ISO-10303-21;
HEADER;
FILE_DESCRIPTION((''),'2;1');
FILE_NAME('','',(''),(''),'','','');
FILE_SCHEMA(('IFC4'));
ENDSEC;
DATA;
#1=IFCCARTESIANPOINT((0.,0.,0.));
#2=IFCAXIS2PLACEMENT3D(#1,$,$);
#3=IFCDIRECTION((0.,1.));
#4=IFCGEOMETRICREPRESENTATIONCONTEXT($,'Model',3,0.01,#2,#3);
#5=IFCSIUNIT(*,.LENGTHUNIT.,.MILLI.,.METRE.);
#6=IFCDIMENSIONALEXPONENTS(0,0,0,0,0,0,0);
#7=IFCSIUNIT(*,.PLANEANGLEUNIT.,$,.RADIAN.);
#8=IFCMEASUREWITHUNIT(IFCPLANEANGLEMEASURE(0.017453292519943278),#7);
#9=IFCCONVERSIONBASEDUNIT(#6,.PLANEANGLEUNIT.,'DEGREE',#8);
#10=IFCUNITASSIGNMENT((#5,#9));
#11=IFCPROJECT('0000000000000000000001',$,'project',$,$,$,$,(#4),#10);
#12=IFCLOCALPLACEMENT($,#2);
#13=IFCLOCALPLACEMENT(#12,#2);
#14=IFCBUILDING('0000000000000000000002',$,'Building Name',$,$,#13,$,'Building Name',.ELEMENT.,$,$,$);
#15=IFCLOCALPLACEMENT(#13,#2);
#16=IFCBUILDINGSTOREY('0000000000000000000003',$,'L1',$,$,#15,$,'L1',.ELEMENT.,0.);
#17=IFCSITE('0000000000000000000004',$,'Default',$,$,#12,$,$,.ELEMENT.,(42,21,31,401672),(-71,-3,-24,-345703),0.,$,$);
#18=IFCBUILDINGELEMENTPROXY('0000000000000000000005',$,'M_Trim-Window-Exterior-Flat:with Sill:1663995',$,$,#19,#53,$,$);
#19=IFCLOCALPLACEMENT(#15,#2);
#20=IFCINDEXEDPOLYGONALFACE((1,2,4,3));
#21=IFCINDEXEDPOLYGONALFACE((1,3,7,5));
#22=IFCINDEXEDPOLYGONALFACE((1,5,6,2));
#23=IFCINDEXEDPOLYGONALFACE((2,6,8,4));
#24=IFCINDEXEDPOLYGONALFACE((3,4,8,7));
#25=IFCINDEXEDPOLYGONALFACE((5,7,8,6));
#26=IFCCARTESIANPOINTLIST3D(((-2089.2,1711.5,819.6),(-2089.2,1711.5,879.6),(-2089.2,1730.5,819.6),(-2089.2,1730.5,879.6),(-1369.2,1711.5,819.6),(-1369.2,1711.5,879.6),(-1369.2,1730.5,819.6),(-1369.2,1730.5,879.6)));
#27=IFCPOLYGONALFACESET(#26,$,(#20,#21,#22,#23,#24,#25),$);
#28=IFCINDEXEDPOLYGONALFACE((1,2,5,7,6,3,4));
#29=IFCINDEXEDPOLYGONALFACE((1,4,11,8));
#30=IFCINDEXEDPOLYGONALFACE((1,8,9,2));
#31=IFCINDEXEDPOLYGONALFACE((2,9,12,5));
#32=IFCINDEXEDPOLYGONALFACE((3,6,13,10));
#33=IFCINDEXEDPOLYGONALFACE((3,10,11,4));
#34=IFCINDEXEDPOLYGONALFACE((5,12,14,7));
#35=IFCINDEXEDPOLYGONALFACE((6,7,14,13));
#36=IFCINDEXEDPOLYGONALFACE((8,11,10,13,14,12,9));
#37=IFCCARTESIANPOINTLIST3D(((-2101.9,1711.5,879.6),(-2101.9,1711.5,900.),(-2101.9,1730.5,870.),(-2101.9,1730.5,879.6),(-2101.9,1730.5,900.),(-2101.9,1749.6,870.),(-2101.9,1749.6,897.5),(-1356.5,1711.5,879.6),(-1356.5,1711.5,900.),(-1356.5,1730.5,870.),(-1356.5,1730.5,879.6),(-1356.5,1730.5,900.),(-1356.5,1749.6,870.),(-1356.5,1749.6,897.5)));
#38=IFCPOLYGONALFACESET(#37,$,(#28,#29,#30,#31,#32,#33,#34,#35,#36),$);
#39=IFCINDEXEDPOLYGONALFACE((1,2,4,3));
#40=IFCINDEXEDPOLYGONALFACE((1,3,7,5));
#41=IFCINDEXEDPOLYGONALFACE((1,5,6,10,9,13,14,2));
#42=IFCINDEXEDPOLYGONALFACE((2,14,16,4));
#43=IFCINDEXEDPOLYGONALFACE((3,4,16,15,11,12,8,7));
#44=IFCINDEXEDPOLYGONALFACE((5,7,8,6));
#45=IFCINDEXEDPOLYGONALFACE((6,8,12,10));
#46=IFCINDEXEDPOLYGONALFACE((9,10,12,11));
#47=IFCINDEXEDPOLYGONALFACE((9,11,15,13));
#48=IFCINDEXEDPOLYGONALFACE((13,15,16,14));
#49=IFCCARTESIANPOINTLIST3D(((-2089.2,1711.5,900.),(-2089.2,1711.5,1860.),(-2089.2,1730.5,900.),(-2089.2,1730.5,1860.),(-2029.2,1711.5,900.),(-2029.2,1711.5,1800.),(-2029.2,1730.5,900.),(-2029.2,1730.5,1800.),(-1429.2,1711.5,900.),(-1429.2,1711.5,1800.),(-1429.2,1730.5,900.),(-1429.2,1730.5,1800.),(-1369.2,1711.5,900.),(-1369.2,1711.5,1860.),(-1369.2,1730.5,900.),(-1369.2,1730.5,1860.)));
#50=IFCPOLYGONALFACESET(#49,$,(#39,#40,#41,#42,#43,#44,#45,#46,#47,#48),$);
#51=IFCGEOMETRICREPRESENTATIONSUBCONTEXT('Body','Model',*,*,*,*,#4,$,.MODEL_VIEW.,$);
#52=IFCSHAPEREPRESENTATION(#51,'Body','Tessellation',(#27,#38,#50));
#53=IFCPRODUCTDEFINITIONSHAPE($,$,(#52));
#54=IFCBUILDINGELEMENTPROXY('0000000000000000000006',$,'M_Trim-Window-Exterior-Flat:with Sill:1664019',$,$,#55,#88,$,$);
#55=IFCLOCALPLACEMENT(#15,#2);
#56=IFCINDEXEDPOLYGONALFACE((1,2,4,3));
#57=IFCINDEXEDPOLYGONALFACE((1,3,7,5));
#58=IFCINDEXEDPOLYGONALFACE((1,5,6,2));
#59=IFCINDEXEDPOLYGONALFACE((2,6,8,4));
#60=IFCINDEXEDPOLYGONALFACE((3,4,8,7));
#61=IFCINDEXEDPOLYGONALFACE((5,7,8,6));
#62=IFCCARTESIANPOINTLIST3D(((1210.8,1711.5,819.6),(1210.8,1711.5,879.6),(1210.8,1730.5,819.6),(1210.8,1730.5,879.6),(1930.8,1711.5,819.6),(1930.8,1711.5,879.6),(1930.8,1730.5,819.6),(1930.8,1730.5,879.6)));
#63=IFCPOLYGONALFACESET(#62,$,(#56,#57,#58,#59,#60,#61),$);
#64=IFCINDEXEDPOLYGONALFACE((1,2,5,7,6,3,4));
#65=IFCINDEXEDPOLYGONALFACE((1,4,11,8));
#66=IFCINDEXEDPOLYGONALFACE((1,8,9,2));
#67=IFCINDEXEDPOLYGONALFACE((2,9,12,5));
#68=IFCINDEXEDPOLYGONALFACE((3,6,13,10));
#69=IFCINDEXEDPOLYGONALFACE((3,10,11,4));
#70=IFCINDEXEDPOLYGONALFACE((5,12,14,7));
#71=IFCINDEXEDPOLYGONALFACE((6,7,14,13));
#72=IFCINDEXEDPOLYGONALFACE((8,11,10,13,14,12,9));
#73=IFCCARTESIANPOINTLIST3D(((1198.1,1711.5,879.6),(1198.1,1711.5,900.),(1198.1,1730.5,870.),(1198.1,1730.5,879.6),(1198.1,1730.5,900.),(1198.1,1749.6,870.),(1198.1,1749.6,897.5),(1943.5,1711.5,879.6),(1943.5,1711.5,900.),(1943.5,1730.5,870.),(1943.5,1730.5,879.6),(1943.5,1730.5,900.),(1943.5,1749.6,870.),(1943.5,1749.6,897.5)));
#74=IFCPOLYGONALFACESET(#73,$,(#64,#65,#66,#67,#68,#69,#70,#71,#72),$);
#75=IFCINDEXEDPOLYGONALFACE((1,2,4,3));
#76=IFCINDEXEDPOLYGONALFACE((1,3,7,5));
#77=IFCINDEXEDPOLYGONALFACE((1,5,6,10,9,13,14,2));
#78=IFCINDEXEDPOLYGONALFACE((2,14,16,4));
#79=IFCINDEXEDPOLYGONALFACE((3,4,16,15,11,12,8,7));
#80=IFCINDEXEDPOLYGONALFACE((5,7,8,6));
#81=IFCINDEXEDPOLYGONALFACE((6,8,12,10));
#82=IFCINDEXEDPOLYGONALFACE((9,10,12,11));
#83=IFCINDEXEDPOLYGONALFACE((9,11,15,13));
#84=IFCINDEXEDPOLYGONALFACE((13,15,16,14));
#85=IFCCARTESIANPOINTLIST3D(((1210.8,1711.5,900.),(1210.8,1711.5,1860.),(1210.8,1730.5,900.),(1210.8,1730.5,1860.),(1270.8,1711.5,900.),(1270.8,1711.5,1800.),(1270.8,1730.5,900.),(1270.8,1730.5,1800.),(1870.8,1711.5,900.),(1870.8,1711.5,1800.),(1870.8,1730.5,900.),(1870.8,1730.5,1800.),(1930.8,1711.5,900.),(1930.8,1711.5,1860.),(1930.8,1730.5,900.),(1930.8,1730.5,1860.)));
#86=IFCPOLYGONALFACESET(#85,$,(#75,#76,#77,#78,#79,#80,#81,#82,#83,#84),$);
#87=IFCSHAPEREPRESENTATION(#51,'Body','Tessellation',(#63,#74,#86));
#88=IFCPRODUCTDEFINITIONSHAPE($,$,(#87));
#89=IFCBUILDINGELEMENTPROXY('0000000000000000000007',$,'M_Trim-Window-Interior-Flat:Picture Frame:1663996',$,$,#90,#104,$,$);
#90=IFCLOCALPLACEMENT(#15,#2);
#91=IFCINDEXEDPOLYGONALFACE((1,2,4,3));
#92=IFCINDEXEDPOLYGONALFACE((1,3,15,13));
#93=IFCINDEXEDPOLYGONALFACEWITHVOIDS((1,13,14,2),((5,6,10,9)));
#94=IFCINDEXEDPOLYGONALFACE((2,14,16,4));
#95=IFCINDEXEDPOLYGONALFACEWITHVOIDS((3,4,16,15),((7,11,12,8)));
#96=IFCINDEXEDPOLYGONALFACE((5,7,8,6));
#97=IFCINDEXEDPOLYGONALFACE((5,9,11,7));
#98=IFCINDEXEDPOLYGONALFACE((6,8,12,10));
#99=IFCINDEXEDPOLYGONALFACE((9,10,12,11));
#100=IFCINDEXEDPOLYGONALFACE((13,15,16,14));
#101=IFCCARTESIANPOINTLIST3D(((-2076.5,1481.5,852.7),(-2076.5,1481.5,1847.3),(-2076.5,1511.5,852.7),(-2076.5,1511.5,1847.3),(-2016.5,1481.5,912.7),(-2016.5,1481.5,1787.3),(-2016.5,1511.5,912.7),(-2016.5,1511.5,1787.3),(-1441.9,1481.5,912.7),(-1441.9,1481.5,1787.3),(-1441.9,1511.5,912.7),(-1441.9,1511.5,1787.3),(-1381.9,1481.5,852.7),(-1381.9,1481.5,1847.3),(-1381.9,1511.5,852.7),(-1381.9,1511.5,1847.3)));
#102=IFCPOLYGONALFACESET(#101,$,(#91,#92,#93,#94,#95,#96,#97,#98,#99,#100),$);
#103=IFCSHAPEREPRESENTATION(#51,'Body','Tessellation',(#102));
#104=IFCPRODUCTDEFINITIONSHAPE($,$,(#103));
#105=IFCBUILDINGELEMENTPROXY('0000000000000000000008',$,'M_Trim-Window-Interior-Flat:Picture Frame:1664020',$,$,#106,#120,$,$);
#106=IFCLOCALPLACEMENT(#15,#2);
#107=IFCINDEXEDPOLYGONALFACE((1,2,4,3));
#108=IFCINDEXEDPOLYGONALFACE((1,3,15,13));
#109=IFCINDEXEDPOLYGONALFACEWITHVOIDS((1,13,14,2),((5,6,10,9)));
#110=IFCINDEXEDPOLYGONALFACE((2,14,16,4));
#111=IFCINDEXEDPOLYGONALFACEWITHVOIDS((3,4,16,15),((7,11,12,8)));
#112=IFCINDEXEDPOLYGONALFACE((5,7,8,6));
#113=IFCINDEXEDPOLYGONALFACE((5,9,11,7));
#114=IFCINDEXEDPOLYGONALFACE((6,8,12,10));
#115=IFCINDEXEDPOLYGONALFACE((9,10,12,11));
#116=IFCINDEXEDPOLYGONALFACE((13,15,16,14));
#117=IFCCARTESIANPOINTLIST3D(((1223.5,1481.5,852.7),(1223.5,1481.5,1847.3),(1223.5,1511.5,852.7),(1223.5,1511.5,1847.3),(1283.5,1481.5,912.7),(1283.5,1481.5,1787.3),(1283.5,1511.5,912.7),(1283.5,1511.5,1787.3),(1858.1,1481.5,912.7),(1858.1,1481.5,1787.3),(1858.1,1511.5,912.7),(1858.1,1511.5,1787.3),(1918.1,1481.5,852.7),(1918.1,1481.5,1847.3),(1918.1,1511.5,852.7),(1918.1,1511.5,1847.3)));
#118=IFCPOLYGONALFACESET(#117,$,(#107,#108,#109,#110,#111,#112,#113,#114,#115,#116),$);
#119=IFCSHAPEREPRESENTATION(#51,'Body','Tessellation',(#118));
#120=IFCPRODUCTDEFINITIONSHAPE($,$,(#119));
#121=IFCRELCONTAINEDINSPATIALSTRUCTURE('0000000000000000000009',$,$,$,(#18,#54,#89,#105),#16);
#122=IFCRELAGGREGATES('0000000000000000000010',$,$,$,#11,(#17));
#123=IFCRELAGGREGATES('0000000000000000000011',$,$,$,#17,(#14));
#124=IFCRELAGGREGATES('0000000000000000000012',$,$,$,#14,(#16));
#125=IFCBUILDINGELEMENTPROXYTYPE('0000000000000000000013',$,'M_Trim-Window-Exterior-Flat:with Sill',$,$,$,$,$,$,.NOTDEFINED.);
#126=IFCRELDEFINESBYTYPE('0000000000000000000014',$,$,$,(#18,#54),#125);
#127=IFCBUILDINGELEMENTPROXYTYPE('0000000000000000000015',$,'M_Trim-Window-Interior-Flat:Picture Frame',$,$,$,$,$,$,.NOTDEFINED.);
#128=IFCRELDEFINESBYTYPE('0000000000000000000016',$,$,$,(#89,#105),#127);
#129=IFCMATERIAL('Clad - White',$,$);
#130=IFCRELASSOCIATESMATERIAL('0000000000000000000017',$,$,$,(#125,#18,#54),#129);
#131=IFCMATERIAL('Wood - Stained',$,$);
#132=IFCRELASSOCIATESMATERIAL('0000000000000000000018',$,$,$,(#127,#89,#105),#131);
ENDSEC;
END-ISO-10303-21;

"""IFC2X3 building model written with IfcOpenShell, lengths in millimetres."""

from ifc_helpers import new_model, entity, si_unit, converted_unit, direction, frame, frame_2d, origin, place, context, subcontext, project, spatial, polyline, rectangle, outline, extrude, source, transform, mapped, material, type_object, type_shapes, element, save


model = new_model("IFC2X3")

# Units and contexts
model_context = context("Model", 3, precision=0.01, world=origin(), true_north=direction((0.0, 1.0)))
body_context = subcontext(model_context, "Body", "Model", "MODEL_VIEW")
ifc_project = project(units=[si_unit("LENGTHUNIT", "METRE", prefix="MILLI"), converted_unit("PLANEANGLEUNIT", "DEGREE", entity("IfcPlaneAngleMeasure", 0.017453292519943278), si_unit("PLANEANGLEUNIT", "RADIAN"), dimensions=[0, 0, 0, 0, 0, 0, 0])], contexts=[model_context])

# Site, building, storey
site_placement = place(None, origin())
site = spatial("IfcSite", under=ifc_project, at=site_placement, Name="Default", CompositionType="ELEMENT", RefLatitude=(42, 21, 31, 401672), RefLongitude=(-71, -3, -24, -345703), RefElevation=0.0)
building_placement = place(site_placement, origin())
building = spatial("IfcBuilding", under=site, at=building_placement, Name="Building Name", LongName="Building Name", CompositionType="ELEMENT")
storey_placement = place(building_placement, origin())
storey = spatial("IfcBuildingStorey", under=building, at=storey_placement, Name="L1", LongName="L1", CompositionType="ELEMENT", Elevation=0.0)

# Building element proxies
ifc_material_1 = material(Name="Clad - White")
ifc_material_2 = material(Name="Wood - Stained")
building_element_proxy_type_1 = type_object("IfcBuildingElementProxyType", Name="M_Trim-Window-Exterior-Flat:with Sill", PredefinedType="NOTDEFINED", material=ifc_material_1)
shared_shape_1 = source(origin(), body_context, "Body", "SweptSolid", [
    extrude(rectangle(XDim=720.0, YDim=60.0, at=frame_2d((0.0, 0.0), x_axis=(1.0, 0.0))), frame((0.0, -950.4, 0.0), z_axis=(0.0, 0.0, 1.0), x_axis=(-1.0, 0.0, 0.0)), (0.0, 0.0, 1.0), 19.0),
    extrude(outline(polyline([(-19.0, -15.2), (0.0, -15.2), (0.0, -5.7), (19.0, -5.7), (19.0, 14.8), (0.0, 14.8), (-19.0, 12.3), (-19.0, -15.2)])), frame((-372.7, -914.8, 19.0), z_axis=(1.0, 0.0, 0.0), x_axis=(0.0, 0.0, -1.0)), (0.0, 0.0, 1.0), 745.4),
    extrude(outline(polyline([(-495.0, -360.0), (465.0, -360.0), (465.0, -300.0), (-435.0, -300.0), (-435.0, 300.0), (465.0, 300.0), (465.0, 360.0), (-495.0, 360.0), (-495.0, -360.0)])), frame((0.0, -435.0, 0.0), z_axis=(0.0, 0.0, 1.0), x_axis=(0.0, -1.0, 0.0)), (0.0, 0.0, 1.0), 19.0),
])
type_shapes(building_element_proxy_type_1, [shared_shape_1])
for number, where, z_axis, x_axis, name in (
    (1, (-1729.2, 1711.5, 1800.0), (0.0, 1.0, 0.0), (-1.0, 0.0, 0.0), "M_Trim-Window-Exterior-Flat:with Sill:1663995"),
    (2, (1570.8, 1711.5, 1800.0), (0.0, 1.0, 0.0), (-1.0, 0.0, 0.0), "M_Trim-Window-Exterior-Flat:with Sill:1664019"),
):
    element("IfcBuildingElementProxy", number, at=place(storey_placement, frame(where, z_axis=z_axis, x_axis=x_axis)), inside=storey, type_object=building_element_proxy_type_1, material=ifc_material_1, Name=name, context=body_context, shape_type="MappedRepresentation", body=[
        mapped(shared_shape_1, transform((0.0, 0.0, 0.0), scale=1.0)),
    ])
building_element_proxy_type_2 = type_object("IfcBuildingElementProxyType", Name="M_Trim-Window-Interior-Flat:Picture Frame", PredefinedType="NOTDEFINED", material=ifc_material_2)
shared_shape_2 = source(origin(), body_context, "Body", "SweptSolid", [
    extrude(outline(polyline([(-347.3, -497.3), (347.3, -497.3), (347.3, 497.3), (-347.3, 497.3), (-347.3, -497.3)]), holes=[polyline([(-287.3, -437.3), (-287.3, 437.3), (287.3, 437.3), (287.3, -437.3), (-287.3, -437.3)])]), frame((0.0, -450.0, 0.0), z_axis=(0.0, 0.0, 1.0), x_axis=(-1.0, 0.0, 0.0)), (0.0, 0.0, 1.0), 30.0),
])
type_shapes(building_element_proxy_type_2, [shared_shape_2])
for number, where, z_axis, x_axis, name in (
    (3, (-1729.2, 1511.5, 1800.0), (0.0, -1.0, 0.0), (1.0, 0.0, 0.0), "M_Trim-Window-Interior-Flat:Picture Frame:1663996"),
    (4, (1570.8, 1511.5, 1800.0), (0.0, -1.0, 0.0), (1.0, 0.0, 0.0), "M_Trim-Window-Interior-Flat:Picture Frame:1664020"),
):
    element("IfcBuildingElementProxy", number, at=place(storey_placement, frame(where, z_axis=z_axis, x_axis=x_axis)), inside=storey, type_object=building_element_proxy_type_2, material=ifc_material_2, Name=name, context=body_context, shape_type="MappedRepresentation", body=[
        mapped(shared_shape_2, transform((0.0, 0.0, 0.0), scale=1.0)),
    ])

save(model, "model.ifc")
